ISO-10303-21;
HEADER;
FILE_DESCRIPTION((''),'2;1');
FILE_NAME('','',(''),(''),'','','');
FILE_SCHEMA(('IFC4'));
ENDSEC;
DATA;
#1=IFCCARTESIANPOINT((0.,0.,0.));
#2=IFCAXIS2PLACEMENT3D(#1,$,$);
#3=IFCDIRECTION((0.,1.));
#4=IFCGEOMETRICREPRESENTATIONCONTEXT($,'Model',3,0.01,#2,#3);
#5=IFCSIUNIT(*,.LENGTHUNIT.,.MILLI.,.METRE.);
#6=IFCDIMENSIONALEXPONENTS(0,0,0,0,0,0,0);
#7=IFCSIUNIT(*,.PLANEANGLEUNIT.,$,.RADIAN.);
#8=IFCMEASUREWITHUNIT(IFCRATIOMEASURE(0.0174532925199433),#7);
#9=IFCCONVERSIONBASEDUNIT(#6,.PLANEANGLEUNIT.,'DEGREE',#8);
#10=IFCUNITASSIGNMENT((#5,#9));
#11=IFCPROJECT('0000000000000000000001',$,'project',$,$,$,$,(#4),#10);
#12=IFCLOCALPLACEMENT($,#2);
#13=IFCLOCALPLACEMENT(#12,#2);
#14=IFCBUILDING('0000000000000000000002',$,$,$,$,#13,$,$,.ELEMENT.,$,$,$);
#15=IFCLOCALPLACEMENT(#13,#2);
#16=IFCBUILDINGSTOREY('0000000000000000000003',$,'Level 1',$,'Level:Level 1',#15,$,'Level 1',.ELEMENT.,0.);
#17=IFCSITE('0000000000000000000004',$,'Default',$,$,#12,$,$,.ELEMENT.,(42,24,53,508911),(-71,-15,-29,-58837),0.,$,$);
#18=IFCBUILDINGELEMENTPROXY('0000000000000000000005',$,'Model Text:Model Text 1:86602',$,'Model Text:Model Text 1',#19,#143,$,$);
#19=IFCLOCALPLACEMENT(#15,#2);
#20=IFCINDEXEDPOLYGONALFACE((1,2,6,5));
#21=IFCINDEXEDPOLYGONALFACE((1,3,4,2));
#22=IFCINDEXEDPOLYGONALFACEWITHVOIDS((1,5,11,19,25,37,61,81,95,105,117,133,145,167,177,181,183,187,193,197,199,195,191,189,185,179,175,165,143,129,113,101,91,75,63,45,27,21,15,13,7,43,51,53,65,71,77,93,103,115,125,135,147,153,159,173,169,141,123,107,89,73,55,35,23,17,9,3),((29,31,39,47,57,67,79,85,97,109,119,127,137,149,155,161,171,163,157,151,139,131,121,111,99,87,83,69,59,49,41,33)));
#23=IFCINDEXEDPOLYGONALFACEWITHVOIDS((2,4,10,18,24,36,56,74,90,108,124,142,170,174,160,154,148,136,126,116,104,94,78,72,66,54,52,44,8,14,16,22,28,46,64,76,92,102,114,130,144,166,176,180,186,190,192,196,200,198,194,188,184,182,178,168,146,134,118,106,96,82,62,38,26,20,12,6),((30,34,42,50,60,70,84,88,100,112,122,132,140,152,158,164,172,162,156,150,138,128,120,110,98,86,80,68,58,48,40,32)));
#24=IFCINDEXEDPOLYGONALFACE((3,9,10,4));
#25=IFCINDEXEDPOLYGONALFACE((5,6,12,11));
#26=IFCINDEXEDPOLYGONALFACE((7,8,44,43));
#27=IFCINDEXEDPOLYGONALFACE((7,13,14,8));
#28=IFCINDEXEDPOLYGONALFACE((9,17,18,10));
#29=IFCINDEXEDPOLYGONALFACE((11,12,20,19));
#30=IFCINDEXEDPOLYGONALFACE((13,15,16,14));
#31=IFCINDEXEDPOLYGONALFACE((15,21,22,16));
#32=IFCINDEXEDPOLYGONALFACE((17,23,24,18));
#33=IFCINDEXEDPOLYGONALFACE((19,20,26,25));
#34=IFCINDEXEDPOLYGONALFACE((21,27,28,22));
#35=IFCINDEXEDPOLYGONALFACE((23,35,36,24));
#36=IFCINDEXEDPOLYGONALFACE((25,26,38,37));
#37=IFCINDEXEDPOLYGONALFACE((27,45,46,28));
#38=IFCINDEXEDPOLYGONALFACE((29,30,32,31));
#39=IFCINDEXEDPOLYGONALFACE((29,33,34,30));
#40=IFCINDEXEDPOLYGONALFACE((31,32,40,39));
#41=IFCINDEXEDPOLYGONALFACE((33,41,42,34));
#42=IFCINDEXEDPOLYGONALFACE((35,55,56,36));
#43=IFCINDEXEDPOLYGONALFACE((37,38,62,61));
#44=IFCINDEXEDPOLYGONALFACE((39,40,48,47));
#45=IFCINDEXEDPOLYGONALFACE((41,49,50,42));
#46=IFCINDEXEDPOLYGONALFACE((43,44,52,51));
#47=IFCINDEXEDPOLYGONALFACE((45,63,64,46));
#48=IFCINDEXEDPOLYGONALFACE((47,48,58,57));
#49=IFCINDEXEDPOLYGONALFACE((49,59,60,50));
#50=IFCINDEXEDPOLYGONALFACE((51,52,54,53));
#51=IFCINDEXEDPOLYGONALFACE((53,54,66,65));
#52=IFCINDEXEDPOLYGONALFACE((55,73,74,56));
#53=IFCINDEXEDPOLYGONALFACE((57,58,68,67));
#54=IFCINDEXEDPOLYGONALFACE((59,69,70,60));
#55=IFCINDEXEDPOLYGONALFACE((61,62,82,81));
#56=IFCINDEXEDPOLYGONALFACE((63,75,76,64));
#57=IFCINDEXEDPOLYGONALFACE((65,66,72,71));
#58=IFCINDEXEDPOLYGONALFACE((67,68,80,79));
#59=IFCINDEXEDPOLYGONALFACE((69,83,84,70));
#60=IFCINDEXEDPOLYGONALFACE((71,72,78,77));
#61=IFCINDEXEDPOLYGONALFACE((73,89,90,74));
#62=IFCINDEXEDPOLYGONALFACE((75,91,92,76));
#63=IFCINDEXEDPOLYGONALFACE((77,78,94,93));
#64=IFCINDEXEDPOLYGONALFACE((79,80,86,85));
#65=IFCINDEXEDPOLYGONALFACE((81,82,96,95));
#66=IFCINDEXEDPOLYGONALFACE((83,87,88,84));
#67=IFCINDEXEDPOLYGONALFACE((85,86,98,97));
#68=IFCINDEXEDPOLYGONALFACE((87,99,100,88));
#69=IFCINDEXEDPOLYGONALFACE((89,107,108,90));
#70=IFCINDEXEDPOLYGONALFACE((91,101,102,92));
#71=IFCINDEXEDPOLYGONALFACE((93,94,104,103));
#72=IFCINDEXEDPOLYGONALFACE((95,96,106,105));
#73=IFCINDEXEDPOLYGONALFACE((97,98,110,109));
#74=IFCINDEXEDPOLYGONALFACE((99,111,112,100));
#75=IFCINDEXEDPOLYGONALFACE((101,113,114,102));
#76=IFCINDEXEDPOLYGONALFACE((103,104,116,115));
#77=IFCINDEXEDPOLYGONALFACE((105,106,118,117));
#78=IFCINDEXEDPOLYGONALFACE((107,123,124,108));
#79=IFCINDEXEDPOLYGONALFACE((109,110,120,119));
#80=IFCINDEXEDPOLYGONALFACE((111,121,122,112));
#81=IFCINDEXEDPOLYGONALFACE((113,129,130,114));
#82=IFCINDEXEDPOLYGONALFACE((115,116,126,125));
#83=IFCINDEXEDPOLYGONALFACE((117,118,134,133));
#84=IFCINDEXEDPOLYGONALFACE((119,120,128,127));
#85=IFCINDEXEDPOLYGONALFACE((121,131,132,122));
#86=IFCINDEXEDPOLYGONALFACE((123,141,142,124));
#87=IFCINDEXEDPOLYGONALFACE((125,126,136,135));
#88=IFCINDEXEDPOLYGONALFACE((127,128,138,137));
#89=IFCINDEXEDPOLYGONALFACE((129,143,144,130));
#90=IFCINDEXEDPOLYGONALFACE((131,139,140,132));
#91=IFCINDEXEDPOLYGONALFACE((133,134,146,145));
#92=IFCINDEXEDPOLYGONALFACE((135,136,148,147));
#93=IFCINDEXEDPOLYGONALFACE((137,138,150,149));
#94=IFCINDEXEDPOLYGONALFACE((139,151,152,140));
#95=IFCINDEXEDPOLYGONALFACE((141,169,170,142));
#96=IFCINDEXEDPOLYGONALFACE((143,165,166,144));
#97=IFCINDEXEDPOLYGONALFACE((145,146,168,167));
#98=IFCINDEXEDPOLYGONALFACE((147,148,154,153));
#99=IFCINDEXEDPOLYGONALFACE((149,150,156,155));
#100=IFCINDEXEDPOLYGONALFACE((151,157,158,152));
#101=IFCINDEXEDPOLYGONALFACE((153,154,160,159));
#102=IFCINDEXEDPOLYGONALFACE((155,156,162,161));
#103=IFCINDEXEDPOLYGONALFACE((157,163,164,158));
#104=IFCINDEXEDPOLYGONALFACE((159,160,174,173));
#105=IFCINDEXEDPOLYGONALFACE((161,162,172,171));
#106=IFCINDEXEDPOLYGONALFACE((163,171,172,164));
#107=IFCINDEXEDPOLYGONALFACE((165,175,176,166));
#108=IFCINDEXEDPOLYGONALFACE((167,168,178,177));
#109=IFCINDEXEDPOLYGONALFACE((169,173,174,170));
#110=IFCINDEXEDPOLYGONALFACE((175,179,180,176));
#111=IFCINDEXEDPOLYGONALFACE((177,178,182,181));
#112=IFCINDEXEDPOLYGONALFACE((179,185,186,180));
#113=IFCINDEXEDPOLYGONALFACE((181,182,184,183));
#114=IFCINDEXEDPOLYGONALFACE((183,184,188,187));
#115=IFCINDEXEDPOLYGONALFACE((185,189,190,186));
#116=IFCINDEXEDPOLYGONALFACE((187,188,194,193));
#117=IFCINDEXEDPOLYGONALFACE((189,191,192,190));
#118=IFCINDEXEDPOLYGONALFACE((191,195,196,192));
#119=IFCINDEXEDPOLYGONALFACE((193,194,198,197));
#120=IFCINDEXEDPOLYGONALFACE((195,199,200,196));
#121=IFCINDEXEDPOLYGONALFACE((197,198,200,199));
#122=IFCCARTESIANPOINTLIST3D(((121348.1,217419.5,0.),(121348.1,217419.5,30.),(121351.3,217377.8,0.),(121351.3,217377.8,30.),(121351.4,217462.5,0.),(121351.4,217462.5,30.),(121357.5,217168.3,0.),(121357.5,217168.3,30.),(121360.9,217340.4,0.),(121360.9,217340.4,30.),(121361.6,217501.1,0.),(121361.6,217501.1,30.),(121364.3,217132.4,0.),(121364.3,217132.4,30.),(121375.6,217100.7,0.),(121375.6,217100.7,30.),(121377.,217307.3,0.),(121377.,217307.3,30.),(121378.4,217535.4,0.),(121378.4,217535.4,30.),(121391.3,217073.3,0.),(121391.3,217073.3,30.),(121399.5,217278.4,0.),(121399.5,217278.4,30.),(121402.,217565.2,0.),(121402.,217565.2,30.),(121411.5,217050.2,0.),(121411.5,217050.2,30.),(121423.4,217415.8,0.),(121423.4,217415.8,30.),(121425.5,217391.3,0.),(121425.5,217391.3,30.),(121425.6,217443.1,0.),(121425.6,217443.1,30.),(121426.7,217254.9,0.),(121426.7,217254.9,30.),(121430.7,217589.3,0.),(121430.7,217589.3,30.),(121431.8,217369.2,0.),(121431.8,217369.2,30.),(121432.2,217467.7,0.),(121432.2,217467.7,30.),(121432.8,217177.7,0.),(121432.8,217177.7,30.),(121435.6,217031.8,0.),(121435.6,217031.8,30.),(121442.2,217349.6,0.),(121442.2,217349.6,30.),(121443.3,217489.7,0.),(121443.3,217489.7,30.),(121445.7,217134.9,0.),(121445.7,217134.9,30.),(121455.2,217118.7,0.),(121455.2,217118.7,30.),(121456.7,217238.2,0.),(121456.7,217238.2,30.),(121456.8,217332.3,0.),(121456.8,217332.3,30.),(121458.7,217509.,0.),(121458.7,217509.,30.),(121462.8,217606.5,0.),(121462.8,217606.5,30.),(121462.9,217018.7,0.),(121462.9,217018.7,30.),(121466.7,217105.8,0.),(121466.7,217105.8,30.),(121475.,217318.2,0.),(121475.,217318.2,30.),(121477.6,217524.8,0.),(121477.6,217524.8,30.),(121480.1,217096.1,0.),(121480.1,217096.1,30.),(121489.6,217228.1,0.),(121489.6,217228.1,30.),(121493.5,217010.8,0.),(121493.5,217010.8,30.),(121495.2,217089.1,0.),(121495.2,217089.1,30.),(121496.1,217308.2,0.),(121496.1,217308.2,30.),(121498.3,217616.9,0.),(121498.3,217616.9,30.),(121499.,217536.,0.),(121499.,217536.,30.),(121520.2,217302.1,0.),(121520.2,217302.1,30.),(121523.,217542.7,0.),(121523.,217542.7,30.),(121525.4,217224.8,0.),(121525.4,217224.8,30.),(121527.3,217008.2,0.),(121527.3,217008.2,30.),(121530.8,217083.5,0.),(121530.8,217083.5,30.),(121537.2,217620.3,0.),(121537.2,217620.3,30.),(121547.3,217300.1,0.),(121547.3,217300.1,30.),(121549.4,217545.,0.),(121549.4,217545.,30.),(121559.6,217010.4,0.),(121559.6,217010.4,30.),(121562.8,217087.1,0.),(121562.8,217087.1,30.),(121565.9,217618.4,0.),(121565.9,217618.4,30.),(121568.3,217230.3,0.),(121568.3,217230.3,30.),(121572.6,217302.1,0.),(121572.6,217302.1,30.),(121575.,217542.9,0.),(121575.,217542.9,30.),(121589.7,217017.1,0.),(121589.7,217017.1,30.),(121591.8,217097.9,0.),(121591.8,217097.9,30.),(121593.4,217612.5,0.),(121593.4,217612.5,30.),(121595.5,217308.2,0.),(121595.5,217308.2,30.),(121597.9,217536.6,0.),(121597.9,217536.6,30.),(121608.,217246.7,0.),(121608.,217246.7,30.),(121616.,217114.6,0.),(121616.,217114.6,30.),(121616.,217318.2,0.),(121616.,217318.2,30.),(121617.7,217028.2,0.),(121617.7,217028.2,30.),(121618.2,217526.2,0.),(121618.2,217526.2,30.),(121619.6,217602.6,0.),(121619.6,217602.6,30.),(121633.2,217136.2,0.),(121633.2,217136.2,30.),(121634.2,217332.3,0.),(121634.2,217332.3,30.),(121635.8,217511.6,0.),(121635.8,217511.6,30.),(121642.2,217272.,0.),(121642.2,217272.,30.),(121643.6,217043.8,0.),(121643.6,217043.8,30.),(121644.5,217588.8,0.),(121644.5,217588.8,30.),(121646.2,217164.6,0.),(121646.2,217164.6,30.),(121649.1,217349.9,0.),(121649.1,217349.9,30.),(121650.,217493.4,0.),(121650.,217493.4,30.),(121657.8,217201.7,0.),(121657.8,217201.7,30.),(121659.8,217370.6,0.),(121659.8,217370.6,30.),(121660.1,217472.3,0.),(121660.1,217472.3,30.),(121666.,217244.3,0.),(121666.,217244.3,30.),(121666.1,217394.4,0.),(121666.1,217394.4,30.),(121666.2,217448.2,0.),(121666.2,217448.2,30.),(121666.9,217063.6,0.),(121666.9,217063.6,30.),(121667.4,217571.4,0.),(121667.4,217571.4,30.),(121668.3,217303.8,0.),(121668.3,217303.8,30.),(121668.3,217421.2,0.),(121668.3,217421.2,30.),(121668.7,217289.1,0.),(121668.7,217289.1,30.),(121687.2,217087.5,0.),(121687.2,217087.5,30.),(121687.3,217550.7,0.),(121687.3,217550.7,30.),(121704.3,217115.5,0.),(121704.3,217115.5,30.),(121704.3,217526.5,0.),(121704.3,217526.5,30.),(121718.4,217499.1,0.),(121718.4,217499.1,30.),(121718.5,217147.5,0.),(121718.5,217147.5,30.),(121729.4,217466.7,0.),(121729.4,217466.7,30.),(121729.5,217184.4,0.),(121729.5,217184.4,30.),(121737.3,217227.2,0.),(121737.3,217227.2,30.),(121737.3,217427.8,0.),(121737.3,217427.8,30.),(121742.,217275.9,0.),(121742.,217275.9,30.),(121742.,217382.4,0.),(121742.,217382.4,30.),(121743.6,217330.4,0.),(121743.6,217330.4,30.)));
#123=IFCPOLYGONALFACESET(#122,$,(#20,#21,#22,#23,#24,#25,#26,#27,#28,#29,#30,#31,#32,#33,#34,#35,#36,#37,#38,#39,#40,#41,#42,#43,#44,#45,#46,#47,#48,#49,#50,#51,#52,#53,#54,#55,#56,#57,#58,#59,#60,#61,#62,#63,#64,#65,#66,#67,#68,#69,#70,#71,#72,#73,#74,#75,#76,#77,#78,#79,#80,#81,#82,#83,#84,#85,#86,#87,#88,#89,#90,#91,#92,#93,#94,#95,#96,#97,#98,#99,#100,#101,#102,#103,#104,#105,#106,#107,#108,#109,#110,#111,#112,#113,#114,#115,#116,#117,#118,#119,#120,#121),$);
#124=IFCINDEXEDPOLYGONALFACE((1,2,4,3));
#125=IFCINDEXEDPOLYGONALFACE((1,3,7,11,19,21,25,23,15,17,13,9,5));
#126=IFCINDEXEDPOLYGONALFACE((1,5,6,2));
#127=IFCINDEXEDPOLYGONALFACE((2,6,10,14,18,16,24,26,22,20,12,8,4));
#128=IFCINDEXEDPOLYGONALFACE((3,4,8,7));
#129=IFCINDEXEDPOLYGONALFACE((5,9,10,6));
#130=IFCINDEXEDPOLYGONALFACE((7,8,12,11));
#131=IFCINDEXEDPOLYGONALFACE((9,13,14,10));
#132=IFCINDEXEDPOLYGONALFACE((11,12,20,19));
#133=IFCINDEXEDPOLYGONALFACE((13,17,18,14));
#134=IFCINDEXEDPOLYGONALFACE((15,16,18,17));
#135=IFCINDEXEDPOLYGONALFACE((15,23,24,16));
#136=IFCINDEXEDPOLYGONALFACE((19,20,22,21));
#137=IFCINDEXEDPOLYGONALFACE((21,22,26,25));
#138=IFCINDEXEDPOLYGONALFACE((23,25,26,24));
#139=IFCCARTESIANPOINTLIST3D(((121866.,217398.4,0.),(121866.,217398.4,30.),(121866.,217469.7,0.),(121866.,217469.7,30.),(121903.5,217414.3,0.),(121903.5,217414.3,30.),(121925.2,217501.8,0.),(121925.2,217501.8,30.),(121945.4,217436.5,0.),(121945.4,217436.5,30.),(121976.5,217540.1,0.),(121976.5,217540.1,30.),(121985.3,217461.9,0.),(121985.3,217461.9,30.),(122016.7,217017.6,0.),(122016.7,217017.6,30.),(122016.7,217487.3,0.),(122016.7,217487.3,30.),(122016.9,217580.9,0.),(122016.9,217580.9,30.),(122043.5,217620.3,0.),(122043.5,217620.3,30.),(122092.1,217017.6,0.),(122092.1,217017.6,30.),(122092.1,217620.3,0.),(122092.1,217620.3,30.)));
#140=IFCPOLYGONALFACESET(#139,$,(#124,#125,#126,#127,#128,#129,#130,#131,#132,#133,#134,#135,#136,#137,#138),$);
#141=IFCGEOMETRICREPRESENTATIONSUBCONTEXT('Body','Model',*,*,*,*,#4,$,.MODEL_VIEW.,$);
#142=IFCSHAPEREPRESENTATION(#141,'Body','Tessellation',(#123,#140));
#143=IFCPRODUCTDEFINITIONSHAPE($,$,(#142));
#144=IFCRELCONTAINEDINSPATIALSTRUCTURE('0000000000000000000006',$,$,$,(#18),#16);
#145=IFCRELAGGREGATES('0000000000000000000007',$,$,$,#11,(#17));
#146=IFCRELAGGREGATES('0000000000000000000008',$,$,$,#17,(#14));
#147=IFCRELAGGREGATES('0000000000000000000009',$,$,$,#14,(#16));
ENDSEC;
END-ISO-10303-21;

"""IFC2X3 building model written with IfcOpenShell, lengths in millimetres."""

from ifc_helpers import new_model, entity, si_unit, converted_unit, direction, frame, origin, place, context, subcontext, project, spatial, polyline, outline, extrude, element, save


model = new_model("IFC2X3")

# Units and contexts
model_context = context("Model", 3, precision=0.01, world=origin(), true_north=direction((0.0, 1.0)))
body_context = subcontext(model_context, "Body", "Model", "MODEL_VIEW")
ifc_project = project(units=[si_unit("LENGTHUNIT", "METRE", prefix="MILLI"), converted_unit("PLANEANGLEUNIT", "DEGREE", entity("IfcRatioMeasure", 0.0174532925199433), si_unit("PLANEANGLEUNIT", "RADIAN"), dimensions=[0, 0, 0, 0, 0, 0, 0])], contexts=[model_context])

# Site, building, storey
site_placement = place(None, origin())
site = spatial("IfcSite", under=ifc_project, at=site_placement, Name="Default", CompositionType="ELEMENT", RefLatitude=(42, 24, 53, 508911), RefLongitude=(-71, -15, -29, -58837), RefElevation=0.0)
building_placement = place(site_placement, origin())
building = spatial("IfcBuilding", under=site, at=building_placement, CompositionType="ELEMENT")
storey_placement = place(building_placement, origin())
storey = spatial("IfcBuildingStorey", under=building, at=storey_placement, Name="Level 1", ObjectType="Level:Level 1", LongName="Level 1", CompositionType="ELEMENT", Elevation=0.0)

# Building element proxy
proxy_1_placement = place(storey_placement, origin())
element("IfcBuildingElementProxy", 1, at=proxy_1_placement, inside=storey, Name="Model Text:Model Text 1:86602", ObjectType="Model Text:Model Text 1", context=body_context, shape_type="SweptSolid", body=[
    extrude(outline(polyline([(63.9, -207.4), (100.4, -207.4), (133.6, -202.3), (163.4, -191.9), (189.9, -176.3), (212.5, -156.1), (230.5, -131.7), (243.9, -103.1), (252.8, -70.4), (256.6, -38.2), (255.6, -7.4), (249.9, 22.2), (239.4, 50.6), (224.2, 77.1), (204.5, 101.5), (180.3, 123.5), (151.4, 143.4), (117.2, 161.0), (76.6, 176.7), (29.6, 190.4), (-23.7, 202.1), (-75.0, 210.2), (-120.5, 214.0), (-160.2, 213.5), (-194.1, 208.7), (-223.7, 199.9), (-250.5, 187.7), (-274.6, 172.0), (-296.0, 152.8), (-314.2, 130.8), (-328.7, 106.9), (-339.6, 81.0), (-346.9, 53.2), (-350.7, 14.3), (-347.2, -22.5), (-336.2, -57.2), (-317.8, -89.9), (-292.9, -118.6), (-262.4, -141.6), (-226.4, -158.7), (-184.7, -170.0), (-143.2, -174.6), (-104.6, -172.1), (-69.1, -162.4), (-36.5, -145.7), (-8.4, -123.4), (13.6, -97.0), (29.6, -66.5), (39.6, -32.0), (42.2, 11.2), (33.4, 53.3), (14.9, 91.6), (-11.5, 123.1), (3.0, 120.8), (46.6, 109.8), (86.9, 93.9), (121.2, 75.6), (146.7, 57.5), (164.6, 36.5), (176.6, 9.7), (181.8, -20.8), (179.4, -52.9), (167.3, -86.8), (157.6, -100.4), (145.5, -111.8), (130.8, -120.7), (113.0, -127.0), (68.6, -131.7), (63.9, -207.4)]), holes=[polyline([(-126.9, 145.0), (-100.9, 137.9), (-78.7, 127.2), (-60.4, 112.9), (-45.8, 94.9), (-35.4, 74.4), (-29.3, 52.4), (-27.7, 28.8), (-30.4, 3.6), (-37.4, -22.6), (-47.8, -45.2), (-61.6, -64.1), (-78.8, -79.4), (-98.5, -90.5), (-119.8, -97.1), (-142.6, -99.1), (-167.1, -96.6), (-193.5, -89.4), (-216.5, -78.3), (-236.0, -63.4), (-252.1, -44.6), (-264.0, -23.1), (-271.1, 0.0), (-273.3, 24.8), (-270.6, 51.2), (-263.8, 75.9), (-253.4, 97.3), (-239.3, 115.2), (-221.7, 129.8), (-201.2, 140.4), (-178.6, 146.5), (-153.8, 148.0), (-126.9, 145.0)])]), frame((121549.4, 217269.6, 0.0), z_axis=(0.0, 0.0, 1.0), x_axis=(0.185967, -0.982556, 0.0)), (0.0, 0.0, 1.0), 30.0),
    extrude(outline(polyline([(-410.6, -111.6), (192.1, -111.6), (192.1, -63.1), (152.7, -36.4), (111.9, 4.0), (73.6, 55.2), (41.4, 114.4), (-29.8, 114.4), (-13.9, 77.0), (8.3, 35.1), (33.7, -4.8), (59.1, -36.3), (-410.6, -36.3), (-410.6, -111.6)])), frame((121980.5, 217428.2, 0.0), z_axis=(0.0, 0.0, 1.0), x_axis=(0.0, 1.0, 0.0)), (0.0, 0.0, 1.0), 30.0),
])

save(model, "model.ifc")
